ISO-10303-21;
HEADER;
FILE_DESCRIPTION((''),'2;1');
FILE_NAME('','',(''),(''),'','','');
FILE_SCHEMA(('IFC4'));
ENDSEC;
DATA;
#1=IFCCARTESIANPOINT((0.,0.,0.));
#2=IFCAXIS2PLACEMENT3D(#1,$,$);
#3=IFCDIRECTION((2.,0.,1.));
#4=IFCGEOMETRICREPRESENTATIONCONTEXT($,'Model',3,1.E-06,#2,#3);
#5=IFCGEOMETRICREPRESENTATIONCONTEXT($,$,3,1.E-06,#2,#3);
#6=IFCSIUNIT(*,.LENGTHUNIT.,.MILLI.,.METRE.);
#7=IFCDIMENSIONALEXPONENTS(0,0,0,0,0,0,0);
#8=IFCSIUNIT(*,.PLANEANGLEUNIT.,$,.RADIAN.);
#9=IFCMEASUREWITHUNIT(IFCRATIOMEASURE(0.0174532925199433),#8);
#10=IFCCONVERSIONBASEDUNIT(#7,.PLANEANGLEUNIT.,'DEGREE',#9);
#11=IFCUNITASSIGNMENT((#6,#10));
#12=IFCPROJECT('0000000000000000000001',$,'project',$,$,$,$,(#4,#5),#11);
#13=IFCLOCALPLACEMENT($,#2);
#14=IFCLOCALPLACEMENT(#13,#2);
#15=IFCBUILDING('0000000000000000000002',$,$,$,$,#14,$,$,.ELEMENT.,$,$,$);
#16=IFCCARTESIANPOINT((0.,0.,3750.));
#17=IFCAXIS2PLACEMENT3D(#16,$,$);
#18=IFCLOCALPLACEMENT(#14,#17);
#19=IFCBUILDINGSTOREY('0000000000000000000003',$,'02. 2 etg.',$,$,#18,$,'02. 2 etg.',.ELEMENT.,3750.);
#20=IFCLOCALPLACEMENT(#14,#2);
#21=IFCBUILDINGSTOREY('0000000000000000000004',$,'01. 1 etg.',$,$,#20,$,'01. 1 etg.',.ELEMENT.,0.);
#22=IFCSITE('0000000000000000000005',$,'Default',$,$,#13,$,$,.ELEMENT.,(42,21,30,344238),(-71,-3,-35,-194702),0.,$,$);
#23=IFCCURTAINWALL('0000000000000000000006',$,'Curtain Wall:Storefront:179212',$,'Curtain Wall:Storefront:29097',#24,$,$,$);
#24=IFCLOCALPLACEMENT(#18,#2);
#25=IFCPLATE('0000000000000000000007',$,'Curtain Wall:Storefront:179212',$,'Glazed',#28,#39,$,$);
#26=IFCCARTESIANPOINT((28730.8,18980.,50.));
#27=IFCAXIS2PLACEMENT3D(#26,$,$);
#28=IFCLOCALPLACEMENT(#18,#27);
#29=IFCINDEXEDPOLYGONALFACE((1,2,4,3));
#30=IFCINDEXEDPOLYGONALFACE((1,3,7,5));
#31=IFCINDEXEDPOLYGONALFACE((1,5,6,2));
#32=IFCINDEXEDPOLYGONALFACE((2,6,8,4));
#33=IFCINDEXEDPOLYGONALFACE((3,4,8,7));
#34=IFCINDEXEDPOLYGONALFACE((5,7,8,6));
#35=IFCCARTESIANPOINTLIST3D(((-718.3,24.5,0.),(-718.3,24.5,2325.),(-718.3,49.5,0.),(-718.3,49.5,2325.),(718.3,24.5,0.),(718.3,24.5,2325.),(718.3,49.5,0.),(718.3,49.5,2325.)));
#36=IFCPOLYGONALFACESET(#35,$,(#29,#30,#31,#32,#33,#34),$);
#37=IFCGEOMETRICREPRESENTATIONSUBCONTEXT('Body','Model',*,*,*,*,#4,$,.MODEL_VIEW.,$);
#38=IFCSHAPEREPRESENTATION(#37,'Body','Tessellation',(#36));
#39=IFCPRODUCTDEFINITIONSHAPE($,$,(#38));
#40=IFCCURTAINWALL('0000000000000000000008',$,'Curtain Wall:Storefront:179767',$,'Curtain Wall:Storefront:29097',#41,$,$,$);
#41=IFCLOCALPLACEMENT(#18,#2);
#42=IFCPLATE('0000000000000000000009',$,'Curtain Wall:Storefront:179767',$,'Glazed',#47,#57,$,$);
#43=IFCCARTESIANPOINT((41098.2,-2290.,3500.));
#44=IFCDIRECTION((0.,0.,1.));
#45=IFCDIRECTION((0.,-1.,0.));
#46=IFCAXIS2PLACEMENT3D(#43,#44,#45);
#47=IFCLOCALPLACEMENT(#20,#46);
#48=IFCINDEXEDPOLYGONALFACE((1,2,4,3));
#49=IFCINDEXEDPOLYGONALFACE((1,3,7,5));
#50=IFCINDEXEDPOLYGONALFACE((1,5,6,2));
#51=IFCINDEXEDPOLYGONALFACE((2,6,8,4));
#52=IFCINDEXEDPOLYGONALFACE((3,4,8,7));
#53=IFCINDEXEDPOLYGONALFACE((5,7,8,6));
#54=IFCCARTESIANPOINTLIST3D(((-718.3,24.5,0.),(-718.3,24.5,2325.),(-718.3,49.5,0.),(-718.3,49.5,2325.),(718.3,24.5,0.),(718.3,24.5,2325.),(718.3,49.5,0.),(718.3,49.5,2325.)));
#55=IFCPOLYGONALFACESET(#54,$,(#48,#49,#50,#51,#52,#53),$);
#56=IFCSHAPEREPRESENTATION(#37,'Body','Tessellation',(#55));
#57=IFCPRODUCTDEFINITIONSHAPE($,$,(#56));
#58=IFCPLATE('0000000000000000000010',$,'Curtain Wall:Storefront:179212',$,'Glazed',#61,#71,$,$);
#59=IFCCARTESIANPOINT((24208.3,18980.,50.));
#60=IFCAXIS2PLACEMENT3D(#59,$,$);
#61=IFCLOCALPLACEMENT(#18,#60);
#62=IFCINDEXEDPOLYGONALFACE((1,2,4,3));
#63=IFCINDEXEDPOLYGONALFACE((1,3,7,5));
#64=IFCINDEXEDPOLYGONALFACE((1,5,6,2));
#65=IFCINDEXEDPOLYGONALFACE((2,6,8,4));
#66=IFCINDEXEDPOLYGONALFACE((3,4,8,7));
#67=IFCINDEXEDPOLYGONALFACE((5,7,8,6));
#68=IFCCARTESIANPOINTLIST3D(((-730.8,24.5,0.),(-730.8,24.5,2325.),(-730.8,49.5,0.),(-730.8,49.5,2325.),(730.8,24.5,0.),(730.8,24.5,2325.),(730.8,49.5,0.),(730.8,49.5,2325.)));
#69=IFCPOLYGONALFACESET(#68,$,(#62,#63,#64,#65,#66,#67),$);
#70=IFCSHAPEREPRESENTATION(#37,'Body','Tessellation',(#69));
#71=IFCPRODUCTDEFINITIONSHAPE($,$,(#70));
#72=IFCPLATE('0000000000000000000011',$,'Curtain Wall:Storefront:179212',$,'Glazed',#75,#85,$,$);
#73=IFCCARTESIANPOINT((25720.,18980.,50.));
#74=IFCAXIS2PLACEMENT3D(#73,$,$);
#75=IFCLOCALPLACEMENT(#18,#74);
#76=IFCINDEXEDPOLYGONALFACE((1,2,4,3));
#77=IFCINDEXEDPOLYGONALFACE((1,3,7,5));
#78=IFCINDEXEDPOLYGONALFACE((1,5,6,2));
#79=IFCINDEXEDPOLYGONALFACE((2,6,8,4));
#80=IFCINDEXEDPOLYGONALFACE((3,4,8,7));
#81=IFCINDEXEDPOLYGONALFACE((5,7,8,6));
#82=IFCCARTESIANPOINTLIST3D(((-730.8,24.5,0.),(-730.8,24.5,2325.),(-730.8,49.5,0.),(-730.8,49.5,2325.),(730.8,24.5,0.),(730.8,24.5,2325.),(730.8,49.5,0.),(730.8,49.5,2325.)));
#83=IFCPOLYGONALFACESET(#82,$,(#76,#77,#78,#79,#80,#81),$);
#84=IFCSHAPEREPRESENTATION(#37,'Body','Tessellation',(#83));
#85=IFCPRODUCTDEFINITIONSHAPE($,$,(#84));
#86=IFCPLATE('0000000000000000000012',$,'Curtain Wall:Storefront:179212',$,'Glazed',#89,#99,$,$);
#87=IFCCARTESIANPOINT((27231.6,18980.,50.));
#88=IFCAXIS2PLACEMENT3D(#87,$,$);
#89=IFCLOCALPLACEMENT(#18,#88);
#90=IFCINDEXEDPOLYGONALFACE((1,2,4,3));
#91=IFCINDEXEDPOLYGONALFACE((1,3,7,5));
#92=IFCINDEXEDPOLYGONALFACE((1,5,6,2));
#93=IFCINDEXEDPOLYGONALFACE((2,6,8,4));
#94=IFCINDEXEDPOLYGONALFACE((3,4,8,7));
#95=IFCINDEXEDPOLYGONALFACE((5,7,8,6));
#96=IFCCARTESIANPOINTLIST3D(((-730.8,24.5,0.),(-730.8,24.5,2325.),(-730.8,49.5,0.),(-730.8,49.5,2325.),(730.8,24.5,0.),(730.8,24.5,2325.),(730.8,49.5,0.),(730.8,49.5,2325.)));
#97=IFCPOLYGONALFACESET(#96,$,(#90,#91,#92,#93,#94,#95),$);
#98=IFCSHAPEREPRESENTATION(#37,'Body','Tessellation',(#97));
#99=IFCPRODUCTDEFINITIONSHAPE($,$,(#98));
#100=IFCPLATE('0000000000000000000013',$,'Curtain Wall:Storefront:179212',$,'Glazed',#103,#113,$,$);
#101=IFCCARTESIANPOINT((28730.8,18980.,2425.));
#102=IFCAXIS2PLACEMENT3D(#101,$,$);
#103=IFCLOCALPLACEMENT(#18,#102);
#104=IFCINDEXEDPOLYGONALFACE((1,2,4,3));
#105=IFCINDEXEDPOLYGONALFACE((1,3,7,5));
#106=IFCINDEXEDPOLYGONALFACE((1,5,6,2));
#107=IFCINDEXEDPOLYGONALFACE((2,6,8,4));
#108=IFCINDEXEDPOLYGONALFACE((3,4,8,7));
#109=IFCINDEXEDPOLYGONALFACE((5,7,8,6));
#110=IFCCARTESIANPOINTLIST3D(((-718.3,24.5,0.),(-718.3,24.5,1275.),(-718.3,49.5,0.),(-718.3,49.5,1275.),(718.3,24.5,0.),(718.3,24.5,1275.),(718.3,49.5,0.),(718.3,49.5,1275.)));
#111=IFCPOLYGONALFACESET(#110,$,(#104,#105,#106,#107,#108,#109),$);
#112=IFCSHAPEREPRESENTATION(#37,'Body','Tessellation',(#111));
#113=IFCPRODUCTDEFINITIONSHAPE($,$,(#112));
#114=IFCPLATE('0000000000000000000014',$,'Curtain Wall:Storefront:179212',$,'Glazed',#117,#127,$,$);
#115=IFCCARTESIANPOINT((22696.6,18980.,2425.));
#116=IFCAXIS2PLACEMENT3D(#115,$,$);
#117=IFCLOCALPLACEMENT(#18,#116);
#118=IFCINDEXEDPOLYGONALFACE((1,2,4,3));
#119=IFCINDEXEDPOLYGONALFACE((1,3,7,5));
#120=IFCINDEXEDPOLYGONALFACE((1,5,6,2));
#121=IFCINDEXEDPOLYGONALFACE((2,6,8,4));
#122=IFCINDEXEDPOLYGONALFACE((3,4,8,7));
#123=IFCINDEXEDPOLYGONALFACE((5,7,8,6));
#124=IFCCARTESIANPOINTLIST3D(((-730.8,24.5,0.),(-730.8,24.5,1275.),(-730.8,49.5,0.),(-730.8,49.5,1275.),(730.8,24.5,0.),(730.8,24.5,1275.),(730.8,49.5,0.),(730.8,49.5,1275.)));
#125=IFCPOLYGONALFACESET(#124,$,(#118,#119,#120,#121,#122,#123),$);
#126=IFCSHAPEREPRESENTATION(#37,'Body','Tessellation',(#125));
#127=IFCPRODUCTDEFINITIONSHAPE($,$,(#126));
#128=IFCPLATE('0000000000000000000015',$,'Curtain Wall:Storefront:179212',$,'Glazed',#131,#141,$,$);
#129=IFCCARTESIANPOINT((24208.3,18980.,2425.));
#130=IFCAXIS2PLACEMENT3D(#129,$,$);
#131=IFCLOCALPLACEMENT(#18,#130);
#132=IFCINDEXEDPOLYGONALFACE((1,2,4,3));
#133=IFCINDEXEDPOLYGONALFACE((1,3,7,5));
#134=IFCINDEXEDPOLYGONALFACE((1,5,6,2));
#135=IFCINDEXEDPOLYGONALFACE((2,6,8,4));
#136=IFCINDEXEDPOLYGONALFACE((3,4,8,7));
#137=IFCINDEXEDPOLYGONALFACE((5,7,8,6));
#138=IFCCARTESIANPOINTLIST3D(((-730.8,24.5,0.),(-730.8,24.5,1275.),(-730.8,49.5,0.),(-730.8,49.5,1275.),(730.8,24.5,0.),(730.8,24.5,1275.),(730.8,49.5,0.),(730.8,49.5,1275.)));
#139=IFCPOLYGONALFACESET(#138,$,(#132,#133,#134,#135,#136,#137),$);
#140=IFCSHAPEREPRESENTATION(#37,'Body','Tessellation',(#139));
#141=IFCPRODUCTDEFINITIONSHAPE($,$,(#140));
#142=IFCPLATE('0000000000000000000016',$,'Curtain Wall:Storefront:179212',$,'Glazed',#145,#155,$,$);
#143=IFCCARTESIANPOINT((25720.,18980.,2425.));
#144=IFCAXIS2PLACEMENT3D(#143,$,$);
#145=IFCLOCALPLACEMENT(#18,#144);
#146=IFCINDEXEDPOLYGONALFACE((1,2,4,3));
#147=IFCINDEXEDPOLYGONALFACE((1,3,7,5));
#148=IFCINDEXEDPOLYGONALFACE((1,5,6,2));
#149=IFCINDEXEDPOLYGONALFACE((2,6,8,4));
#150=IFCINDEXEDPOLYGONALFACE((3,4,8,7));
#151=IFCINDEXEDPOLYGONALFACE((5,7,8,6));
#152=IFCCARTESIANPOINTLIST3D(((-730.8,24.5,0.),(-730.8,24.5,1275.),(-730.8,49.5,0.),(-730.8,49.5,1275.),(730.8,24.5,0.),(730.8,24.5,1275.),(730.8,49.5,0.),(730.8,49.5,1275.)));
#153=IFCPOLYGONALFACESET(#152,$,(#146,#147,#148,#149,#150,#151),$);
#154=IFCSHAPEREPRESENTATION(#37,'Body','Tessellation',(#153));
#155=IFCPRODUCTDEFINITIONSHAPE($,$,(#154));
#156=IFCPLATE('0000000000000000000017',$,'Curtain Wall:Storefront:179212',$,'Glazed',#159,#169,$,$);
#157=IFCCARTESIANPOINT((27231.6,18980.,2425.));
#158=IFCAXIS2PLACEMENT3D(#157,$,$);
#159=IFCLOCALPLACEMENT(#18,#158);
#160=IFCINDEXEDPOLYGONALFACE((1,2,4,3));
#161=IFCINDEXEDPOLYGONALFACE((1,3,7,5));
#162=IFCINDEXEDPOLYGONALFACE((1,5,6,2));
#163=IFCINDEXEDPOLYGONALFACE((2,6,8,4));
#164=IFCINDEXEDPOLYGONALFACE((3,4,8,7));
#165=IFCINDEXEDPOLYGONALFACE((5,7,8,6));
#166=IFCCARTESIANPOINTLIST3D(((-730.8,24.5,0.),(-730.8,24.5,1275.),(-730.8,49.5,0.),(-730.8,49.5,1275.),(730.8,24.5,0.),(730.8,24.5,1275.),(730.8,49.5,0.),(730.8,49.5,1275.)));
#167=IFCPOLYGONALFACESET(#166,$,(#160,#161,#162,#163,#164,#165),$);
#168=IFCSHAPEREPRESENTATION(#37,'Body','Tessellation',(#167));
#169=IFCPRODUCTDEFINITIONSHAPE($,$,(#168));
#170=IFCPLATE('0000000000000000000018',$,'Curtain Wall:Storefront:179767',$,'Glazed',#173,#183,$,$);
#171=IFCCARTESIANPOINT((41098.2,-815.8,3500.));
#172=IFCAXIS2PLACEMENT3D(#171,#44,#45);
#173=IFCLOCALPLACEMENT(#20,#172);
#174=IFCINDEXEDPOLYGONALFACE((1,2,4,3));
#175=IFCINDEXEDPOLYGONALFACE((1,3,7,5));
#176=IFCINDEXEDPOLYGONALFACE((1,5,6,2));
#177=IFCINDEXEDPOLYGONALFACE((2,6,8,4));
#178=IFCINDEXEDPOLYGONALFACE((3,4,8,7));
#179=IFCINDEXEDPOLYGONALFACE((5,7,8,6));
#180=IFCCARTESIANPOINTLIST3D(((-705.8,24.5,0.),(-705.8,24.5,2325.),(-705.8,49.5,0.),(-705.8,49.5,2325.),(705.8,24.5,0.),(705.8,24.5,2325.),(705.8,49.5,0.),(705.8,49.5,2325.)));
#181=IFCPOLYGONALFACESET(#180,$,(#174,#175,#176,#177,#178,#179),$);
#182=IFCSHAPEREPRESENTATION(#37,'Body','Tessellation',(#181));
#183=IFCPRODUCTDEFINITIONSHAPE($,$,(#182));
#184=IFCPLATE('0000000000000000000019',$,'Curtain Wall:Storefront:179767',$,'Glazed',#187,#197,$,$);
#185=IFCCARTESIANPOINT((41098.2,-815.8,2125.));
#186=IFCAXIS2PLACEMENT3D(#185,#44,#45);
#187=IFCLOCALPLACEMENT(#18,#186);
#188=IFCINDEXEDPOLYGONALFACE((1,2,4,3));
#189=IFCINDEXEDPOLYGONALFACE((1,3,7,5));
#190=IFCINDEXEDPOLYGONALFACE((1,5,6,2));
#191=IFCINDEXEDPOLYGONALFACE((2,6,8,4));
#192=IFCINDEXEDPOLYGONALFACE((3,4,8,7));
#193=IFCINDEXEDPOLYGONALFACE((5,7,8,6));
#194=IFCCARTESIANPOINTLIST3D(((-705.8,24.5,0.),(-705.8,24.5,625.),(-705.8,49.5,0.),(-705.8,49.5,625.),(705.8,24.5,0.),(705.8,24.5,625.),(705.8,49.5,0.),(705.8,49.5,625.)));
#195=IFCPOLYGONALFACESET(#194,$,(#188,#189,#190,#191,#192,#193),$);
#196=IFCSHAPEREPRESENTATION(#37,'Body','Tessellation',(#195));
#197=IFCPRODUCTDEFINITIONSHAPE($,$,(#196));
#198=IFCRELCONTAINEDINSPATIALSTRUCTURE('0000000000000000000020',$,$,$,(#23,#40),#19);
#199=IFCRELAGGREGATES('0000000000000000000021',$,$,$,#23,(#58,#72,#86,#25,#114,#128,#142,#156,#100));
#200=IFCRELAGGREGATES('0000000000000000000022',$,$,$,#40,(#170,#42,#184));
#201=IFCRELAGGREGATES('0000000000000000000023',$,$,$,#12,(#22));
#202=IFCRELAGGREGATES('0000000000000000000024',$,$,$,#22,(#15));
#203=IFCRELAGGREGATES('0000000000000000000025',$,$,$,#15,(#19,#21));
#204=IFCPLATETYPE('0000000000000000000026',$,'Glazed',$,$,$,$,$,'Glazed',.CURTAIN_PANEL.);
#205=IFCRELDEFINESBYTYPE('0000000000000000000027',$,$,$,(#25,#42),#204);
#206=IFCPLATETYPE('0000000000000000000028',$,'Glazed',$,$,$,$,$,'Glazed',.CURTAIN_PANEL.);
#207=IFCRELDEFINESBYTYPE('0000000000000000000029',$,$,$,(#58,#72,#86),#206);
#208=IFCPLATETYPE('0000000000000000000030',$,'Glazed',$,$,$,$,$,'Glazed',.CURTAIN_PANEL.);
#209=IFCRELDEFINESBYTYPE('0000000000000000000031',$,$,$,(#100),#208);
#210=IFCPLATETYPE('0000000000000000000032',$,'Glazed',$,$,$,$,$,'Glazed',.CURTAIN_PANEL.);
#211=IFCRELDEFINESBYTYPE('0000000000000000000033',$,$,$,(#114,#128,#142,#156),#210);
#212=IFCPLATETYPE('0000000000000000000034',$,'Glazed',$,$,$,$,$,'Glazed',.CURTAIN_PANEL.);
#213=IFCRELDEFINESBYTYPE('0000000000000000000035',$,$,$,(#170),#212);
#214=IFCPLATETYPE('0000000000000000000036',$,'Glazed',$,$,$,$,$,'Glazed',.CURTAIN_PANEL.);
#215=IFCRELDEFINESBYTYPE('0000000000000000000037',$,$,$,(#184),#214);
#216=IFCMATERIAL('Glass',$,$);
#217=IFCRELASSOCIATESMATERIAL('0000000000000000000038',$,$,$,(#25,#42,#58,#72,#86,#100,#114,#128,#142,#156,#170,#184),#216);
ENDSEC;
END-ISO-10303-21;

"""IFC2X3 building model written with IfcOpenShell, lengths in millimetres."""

from ifc_helpers import new_model, entity, si_unit, converted_unit, direction, frame, origin, origin_2d_with_axis, place, context, subcontext, project, spatial, rectangle, extrude, source, transform, mapped, material, type_object, type_shapes, element, aggregate, save


model = new_model("IFC2X3")

# Units and contexts
model_context = context("Model", 3, precision=1e-06, world=origin(), true_north=direction((2.0, 0.0, 1.0)))
context_of_model = context(None, 3, precision=1e-06, world=origin(), true_north=direction((2.0, 0.0, 1.0)))
body_context = subcontext(model_context, "Body", "Model", "MODEL_VIEW")
ifc_project = project(units=[si_unit("LENGTHUNIT", "METRE", prefix="MILLI"), converted_unit("PLANEANGLEUNIT", "DEGREE", entity("IfcRatioMeasure", 0.0174532925199433), si_unit("PLANEANGLEUNIT", "RADIAN"), dimensions=[0, 0, 0, 0, 0, 0, 0])], contexts=[model_context, context_of_model])

# Site, building, storey
site_placement = place(None, origin())
site = spatial("IfcSite", under=ifc_project, at=site_placement, Name="Default", CompositionType="ELEMENT", RefLatitude=(42, 21, 30, 344238), RefLongitude=(-71, -3, -35, -194702), RefElevation=0.0)
building_placement = place(site_placement, origin())
building = spatial("IfcBuilding", under=site, at=building_placement, CompositionType="ELEMENT")
storey_1_placement = place(building_placement, frame((0.0, 0.0, 3750.0)))
storey_1 = spatial("IfcBuildingStorey", under=building, at=storey_1_placement, Name="02. 2 etg.", LongName="02. 2 etg.", CompositionType="ELEMENT", Elevation=3750.0)

# Curtain walls, plates
curtain_wall_1_placement = place(storey_1_placement, origin())
curtain_wall_1 = element("IfcCurtainWall", 1, at=curtain_wall_1_placement, inside=storey_1, Name="Curtain Wall:Storefront:179212", ObjectType="Curtain Wall:Storefront:29097")
ifc_material_1 = material(Name="Glass")
plate_type_1 = type_object("IfcPlateType", Name="Glazed", ElementType="Glazed", PredefinedType="CURTAIN_PANEL")
shared_shape_1 = source(origin(), body_context, "Body", "SweptSolid", [
    extrude(rectangle(XDim=25.0, YDim=1436.7, at=origin_2d_with_axis()), frame((0.0, 37.0, 0.0), z_axis=(0.0, 0.0, 1.0), x_axis=(0.0, 1.0, 0.0)), (0.0, 0.0, 1.0), 2325.0),
])
type_shapes(plate_type_1, [shared_shape_1])
plate_1_placement = place(storey_1_placement, frame((28730.8, 18980.0, 50.0)))
plate_1 = element("IfcPlate", 2, at=plate_1_placement, type_object=plate_type_1, material=ifc_material_1, Name="Curtain Wall:Storefront:179212", ObjectType="Glazed", context=body_context, shape_type="MappedRepresentation", body=[
    mapped(shared_shape_1, transform((0.0, 0.0, 0.0), scale=1.0)),
])
curtain_wall_2_placement = place(storey_1_placement, origin())
curtain_wall_2 = element("IfcCurtainWall", 3, at=curtain_wall_2_placement, inside=storey_1, Name="Curtain Wall:Storefront:179767", ObjectType="Curtain Wall:Storefront:29097")
storey_2_placement = place(building_placement, origin())
plate_2_placement = place(storey_2_placement, frame((41098.2, -2290.0, 3500.0), z_axis=(0.0, 0.0, 1.0), x_axis=(0.0, -1.0, 0.0)))
plate_2 = element("IfcPlate", 4, at=plate_2_placement, type_object=plate_type_1, material=ifc_material_1, Name="Curtain Wall:Storefront:179767", ObjectType="Glazed", context=body_context, shape_type="MappedRepresentation", body=[
    mapped(shared_shape_1, transform((0.0, 0.0, 0.0), scale=1.0)),
])

# Plates
plate_type_2 = type_object("IfcPlateType", Name="Glazed", ElementType="Glazed", PredefinedType="CURTAIN_PANEL")
shared_shape_2 = source(origin(), body_context, "Body", "SweptSolid", [
    extrude(rectangle(XDim=25.0, YDim=1461.7, at=origin_2d_with_axis()), frame((0.0, 37.0, 0.0), z_axis=(0.0, 0.0, 1.0), x_axis=(0.0, 1.0, 0.0)), (0.0, 0.0, 1.0), 2325.0),
])
type_shapes(plate_type_2, [shared_shape_2])
plate_3_placement = place(storey_1_placement, frame((24208.3, 18980.0, 50.0)))
plate_3 = element("IfcPlate", 5, at=plate_3_placement, type_object=plate_type_2, material=ifc_material_1, Name="Curtain Wall:Storefront:179212", ObjectType="Glazed", context=body_context, shape_type="MappedRepresentation", body=[
    mapped(shared_shape_2, transform((0.0, 0.0, 0.0), scale=1.0)),
])
plate_4_placement = place(storey_1_placement, frame((25720.0, 18980.0, 50.0)))
plate_4 = element("IfcPlate", 6, at=plate_4_placement, type_object=plate_type_2, material=ifc_material_1, Name="Curtain Wall:Storefront:179212", ObjectType="Glazed", context=body_context, shape_type="MappedRepresentation", body=[
    mapped(shared_shape_2, transform((0.0, 0.0, 0.0), scale=1.0)),
])
plate_5_placement = place(storey_1_placement, frame((27231.6, 18980.0, 50.0)))
plate_5 = element("IfcPlate", 7, at=plate_5_placement, type_object=plate_type_2, material=ifc_material_1, Name="Curtain Wall:Storefront:179212", ObjectType="Glazed", context=body_context, shape_type="MappedRepresentation", body=[
    mapped(shared_shape_2, transform((0.0, 0.0, 0.0), scale=1.0)),
])
plate_type_3 = type_object("IfcPlateType", Name="Glazed", ElementType="Glazed", PredefinedType="CURTAIN_PANEL")
shared_shape_3 = source(origin(), body_context, "Body", "SweptSolid", [
    extrude(rectangle(XDim=25.0, YDim=1436.7, at=origin_2d_with_axis()), frame((0.0, 37.0, 0.0), z_axis=(0.0, 0.0, 1.0), x_axis=(0.0, 1.0, 0.0)), (0.0, 0.0, 1.0), 1275.0),
])
type_shapes(plate_type_3, [shared_shape_3])
plate_6_placement = place(storey_1_placement, frame((28730.8, 18980.0, 2425.0)))
plate_6 = element("IfcPlate", 8, at=plate_6_placement, type_object=plate_type_3, material=ifc_material_1, Name="Curtain Wall:Storefront:179212", ObjectType="Glazed", context=body_context, shape_type="MappedRepresentation", body=[
    mapped(shared_shape_3, transform((0.0, 0.0, 0.0), scale=1.0)),
])
plate_type_4 = type_object("IfcPlateType", Name="Glazed", ElementType="Glazed", PredefinedType="CURTAIN_PANEL")
shared_shape_4 = source(origin(), body_context, "Body", "SweptSolid", [
    extrude(rectangle(XDim=25.0, YDim=1461.7, at=origin_2d_with_axis()), frame((0.0, 37.0, 0.0), z_axis=(0.0, 0.0, 1.0), x_axis=(0.0, 1.0, 0.0)), (0.0, 0.0, 1.0), 1275.0),
])
type_shapes(plate_type_4, [shared_shape_4])
plate_7_placement = place(storey_1_placement, frame((22696.6, 18980.0, 2425.0)))
plate_7 = element("IfcPlate", 9, at=plate_7_placement, type_object=plate_type_4, material=ifc_material_1, Name="Curtain Wall:Storefront:179212", ObjectType="Glazed", context=body_context, shape_type="MappedRepresentation", body=[
    mapped(shared_shape_4, transform((0.0, 0.0, 0.0), scale=1.0)),
])
plate_8_placement = place(storey_1_placement, frame((24208.3, 18980.0, 2425.0)))
plate_8 = element("IfcPlate", 10, at=plate_8_placement, type_object=plate_type_4, material=ifc_material_1, Name="Curtain Wall:Storefront:179212", ObjectType="Glazed", context=body_context, shape_type="MappedRepresentation", body=[
    mapped(shared_shape_4, transform((0.0, 0.0, 0.0), scale=1.0)),
])
plate_9_placement = place(storey_1_placement, frame((25720.0, 18980.0, 2425.0)))
plate_9 = element("IfcPlate", 11, at=plate_9_placement, type_object=plate_type_4, material=ifc_material_1, Name="Curtain Wall:Storefront:179212", ObjectType="Glazed", context=body_context, shape_type="MappedRepresentation", body=[
    mapped(shared_shape_4, transform((0.0, 0.0, 0.0), scale=1.0)),
])
plate_10_placement = place(storey_1_placement, frame((27231.6, 18980.0, 2425.0)))
plate_10 = element("IfcPlate", 12, at=plate_10_placement, type_object=plate_type_4, material=ifc_material_1, Name="Curtain Wall:Storefront:179212", ObjectType="Glazed", context=body_context, shape_type="MappedRepresentation", body=[
    mapped(shared_shape_4, transform((0.0, 0.0, 0.0), scale=1.0)),
])
aggregate(curtain_wall_1, [plate_3, plate_4, plate_5, plate_1, plate_7, plate_8, plate_9, plate_10, plate_6])
plate_type_5 = type_object("IfcPlateType", Name="Glazed", ElementType="Glazed", PredefinedType="CURTAIN_PANEL")
shared_shape_5 = source(origin(), body_context, "Body", "SweptSolid", [
    extrude(rectangle(XDim=25.0, YDim=1411.7, at=origin_2d_with_axis()), frame((0.0, 37.0, 0.0), z_axis=(0.0, 0.0, 1.0), x_axis=(0.0, 1.0, 0.0)), (0.0, 0.0, 1.0), 2325.0),
])
type_shapes(plate_type_5, [shared_shape_5])
plate_11_placement = place(storey_2_placement, frame((41098.2, -815.8, 3500.0), z_axis=(0.0, 0.0, 1.0), x_axis=(0.0, -1.0, 0.0)))
plate_11 = element("IfcPlate", 13, at=plate_11_placement, type_object=plate_type_5, material=ifc_material_1, Name="Curtain Wall:Storefront:179767", ObjectType="Glazed", context=body_context, shape_type="MappedRepresentation", body=[
    mapped(shared_shape_5, transform((0.0, 0.0, 0.0), scale=1.0)),
])
plate_type_6 = type_object("IfcPlateType", Name="Glazed", ElementType="Glazed", PredefinedType="CURTAIN_PANEL")
shared_shape_6 = source(origin(), body_context, "Body", "SweptSolid", [
    extrude(rectangle(XDim=25.0, YDim=1411.7, at=origin_2d_with_axis()), frame((0.0, 37.0, 0.0), z_axis=(0.0, 0.0, 1.0), x_axis=(0.0, 1.0, 0.0)), (0.0, 0.0, 1.0), 625.0),
])
type_shapes(plate_type_6, [shared_shape_6])
plate_12_placement = place(storey_1_placement, frame((41098.2, -815.8, 2125.0), z_axis=(0.0, 0.0, 1.0), x_axis=(0.0, -1.0, 0.0)))
plate_12 = element("IfcPlate", 14, at=plate_12_placement, type_object=plate_type_6, material=ifc_material_1, Name="Curtain Wall:Storefront:179767", ObjectType="Glazed", context=body_context, shape_type="MappedRepresentation", body=[
    mapped(shared_shape_6, transform((0.0, 0.0, 0.0), scale=1.0)),
])
aggregate(curtain_wall_2, [plate_11, plate_2, plate_12])

# Shared definitions
storey_2 = spatial("IfcBuildingStorey", under=building, at=storey_2_placement, Name="01. 1 etg.", LongName="01. 1 etg.", CompositionType="ELEMENT", Elevation=0.0)

save(model, "model.ifc")
